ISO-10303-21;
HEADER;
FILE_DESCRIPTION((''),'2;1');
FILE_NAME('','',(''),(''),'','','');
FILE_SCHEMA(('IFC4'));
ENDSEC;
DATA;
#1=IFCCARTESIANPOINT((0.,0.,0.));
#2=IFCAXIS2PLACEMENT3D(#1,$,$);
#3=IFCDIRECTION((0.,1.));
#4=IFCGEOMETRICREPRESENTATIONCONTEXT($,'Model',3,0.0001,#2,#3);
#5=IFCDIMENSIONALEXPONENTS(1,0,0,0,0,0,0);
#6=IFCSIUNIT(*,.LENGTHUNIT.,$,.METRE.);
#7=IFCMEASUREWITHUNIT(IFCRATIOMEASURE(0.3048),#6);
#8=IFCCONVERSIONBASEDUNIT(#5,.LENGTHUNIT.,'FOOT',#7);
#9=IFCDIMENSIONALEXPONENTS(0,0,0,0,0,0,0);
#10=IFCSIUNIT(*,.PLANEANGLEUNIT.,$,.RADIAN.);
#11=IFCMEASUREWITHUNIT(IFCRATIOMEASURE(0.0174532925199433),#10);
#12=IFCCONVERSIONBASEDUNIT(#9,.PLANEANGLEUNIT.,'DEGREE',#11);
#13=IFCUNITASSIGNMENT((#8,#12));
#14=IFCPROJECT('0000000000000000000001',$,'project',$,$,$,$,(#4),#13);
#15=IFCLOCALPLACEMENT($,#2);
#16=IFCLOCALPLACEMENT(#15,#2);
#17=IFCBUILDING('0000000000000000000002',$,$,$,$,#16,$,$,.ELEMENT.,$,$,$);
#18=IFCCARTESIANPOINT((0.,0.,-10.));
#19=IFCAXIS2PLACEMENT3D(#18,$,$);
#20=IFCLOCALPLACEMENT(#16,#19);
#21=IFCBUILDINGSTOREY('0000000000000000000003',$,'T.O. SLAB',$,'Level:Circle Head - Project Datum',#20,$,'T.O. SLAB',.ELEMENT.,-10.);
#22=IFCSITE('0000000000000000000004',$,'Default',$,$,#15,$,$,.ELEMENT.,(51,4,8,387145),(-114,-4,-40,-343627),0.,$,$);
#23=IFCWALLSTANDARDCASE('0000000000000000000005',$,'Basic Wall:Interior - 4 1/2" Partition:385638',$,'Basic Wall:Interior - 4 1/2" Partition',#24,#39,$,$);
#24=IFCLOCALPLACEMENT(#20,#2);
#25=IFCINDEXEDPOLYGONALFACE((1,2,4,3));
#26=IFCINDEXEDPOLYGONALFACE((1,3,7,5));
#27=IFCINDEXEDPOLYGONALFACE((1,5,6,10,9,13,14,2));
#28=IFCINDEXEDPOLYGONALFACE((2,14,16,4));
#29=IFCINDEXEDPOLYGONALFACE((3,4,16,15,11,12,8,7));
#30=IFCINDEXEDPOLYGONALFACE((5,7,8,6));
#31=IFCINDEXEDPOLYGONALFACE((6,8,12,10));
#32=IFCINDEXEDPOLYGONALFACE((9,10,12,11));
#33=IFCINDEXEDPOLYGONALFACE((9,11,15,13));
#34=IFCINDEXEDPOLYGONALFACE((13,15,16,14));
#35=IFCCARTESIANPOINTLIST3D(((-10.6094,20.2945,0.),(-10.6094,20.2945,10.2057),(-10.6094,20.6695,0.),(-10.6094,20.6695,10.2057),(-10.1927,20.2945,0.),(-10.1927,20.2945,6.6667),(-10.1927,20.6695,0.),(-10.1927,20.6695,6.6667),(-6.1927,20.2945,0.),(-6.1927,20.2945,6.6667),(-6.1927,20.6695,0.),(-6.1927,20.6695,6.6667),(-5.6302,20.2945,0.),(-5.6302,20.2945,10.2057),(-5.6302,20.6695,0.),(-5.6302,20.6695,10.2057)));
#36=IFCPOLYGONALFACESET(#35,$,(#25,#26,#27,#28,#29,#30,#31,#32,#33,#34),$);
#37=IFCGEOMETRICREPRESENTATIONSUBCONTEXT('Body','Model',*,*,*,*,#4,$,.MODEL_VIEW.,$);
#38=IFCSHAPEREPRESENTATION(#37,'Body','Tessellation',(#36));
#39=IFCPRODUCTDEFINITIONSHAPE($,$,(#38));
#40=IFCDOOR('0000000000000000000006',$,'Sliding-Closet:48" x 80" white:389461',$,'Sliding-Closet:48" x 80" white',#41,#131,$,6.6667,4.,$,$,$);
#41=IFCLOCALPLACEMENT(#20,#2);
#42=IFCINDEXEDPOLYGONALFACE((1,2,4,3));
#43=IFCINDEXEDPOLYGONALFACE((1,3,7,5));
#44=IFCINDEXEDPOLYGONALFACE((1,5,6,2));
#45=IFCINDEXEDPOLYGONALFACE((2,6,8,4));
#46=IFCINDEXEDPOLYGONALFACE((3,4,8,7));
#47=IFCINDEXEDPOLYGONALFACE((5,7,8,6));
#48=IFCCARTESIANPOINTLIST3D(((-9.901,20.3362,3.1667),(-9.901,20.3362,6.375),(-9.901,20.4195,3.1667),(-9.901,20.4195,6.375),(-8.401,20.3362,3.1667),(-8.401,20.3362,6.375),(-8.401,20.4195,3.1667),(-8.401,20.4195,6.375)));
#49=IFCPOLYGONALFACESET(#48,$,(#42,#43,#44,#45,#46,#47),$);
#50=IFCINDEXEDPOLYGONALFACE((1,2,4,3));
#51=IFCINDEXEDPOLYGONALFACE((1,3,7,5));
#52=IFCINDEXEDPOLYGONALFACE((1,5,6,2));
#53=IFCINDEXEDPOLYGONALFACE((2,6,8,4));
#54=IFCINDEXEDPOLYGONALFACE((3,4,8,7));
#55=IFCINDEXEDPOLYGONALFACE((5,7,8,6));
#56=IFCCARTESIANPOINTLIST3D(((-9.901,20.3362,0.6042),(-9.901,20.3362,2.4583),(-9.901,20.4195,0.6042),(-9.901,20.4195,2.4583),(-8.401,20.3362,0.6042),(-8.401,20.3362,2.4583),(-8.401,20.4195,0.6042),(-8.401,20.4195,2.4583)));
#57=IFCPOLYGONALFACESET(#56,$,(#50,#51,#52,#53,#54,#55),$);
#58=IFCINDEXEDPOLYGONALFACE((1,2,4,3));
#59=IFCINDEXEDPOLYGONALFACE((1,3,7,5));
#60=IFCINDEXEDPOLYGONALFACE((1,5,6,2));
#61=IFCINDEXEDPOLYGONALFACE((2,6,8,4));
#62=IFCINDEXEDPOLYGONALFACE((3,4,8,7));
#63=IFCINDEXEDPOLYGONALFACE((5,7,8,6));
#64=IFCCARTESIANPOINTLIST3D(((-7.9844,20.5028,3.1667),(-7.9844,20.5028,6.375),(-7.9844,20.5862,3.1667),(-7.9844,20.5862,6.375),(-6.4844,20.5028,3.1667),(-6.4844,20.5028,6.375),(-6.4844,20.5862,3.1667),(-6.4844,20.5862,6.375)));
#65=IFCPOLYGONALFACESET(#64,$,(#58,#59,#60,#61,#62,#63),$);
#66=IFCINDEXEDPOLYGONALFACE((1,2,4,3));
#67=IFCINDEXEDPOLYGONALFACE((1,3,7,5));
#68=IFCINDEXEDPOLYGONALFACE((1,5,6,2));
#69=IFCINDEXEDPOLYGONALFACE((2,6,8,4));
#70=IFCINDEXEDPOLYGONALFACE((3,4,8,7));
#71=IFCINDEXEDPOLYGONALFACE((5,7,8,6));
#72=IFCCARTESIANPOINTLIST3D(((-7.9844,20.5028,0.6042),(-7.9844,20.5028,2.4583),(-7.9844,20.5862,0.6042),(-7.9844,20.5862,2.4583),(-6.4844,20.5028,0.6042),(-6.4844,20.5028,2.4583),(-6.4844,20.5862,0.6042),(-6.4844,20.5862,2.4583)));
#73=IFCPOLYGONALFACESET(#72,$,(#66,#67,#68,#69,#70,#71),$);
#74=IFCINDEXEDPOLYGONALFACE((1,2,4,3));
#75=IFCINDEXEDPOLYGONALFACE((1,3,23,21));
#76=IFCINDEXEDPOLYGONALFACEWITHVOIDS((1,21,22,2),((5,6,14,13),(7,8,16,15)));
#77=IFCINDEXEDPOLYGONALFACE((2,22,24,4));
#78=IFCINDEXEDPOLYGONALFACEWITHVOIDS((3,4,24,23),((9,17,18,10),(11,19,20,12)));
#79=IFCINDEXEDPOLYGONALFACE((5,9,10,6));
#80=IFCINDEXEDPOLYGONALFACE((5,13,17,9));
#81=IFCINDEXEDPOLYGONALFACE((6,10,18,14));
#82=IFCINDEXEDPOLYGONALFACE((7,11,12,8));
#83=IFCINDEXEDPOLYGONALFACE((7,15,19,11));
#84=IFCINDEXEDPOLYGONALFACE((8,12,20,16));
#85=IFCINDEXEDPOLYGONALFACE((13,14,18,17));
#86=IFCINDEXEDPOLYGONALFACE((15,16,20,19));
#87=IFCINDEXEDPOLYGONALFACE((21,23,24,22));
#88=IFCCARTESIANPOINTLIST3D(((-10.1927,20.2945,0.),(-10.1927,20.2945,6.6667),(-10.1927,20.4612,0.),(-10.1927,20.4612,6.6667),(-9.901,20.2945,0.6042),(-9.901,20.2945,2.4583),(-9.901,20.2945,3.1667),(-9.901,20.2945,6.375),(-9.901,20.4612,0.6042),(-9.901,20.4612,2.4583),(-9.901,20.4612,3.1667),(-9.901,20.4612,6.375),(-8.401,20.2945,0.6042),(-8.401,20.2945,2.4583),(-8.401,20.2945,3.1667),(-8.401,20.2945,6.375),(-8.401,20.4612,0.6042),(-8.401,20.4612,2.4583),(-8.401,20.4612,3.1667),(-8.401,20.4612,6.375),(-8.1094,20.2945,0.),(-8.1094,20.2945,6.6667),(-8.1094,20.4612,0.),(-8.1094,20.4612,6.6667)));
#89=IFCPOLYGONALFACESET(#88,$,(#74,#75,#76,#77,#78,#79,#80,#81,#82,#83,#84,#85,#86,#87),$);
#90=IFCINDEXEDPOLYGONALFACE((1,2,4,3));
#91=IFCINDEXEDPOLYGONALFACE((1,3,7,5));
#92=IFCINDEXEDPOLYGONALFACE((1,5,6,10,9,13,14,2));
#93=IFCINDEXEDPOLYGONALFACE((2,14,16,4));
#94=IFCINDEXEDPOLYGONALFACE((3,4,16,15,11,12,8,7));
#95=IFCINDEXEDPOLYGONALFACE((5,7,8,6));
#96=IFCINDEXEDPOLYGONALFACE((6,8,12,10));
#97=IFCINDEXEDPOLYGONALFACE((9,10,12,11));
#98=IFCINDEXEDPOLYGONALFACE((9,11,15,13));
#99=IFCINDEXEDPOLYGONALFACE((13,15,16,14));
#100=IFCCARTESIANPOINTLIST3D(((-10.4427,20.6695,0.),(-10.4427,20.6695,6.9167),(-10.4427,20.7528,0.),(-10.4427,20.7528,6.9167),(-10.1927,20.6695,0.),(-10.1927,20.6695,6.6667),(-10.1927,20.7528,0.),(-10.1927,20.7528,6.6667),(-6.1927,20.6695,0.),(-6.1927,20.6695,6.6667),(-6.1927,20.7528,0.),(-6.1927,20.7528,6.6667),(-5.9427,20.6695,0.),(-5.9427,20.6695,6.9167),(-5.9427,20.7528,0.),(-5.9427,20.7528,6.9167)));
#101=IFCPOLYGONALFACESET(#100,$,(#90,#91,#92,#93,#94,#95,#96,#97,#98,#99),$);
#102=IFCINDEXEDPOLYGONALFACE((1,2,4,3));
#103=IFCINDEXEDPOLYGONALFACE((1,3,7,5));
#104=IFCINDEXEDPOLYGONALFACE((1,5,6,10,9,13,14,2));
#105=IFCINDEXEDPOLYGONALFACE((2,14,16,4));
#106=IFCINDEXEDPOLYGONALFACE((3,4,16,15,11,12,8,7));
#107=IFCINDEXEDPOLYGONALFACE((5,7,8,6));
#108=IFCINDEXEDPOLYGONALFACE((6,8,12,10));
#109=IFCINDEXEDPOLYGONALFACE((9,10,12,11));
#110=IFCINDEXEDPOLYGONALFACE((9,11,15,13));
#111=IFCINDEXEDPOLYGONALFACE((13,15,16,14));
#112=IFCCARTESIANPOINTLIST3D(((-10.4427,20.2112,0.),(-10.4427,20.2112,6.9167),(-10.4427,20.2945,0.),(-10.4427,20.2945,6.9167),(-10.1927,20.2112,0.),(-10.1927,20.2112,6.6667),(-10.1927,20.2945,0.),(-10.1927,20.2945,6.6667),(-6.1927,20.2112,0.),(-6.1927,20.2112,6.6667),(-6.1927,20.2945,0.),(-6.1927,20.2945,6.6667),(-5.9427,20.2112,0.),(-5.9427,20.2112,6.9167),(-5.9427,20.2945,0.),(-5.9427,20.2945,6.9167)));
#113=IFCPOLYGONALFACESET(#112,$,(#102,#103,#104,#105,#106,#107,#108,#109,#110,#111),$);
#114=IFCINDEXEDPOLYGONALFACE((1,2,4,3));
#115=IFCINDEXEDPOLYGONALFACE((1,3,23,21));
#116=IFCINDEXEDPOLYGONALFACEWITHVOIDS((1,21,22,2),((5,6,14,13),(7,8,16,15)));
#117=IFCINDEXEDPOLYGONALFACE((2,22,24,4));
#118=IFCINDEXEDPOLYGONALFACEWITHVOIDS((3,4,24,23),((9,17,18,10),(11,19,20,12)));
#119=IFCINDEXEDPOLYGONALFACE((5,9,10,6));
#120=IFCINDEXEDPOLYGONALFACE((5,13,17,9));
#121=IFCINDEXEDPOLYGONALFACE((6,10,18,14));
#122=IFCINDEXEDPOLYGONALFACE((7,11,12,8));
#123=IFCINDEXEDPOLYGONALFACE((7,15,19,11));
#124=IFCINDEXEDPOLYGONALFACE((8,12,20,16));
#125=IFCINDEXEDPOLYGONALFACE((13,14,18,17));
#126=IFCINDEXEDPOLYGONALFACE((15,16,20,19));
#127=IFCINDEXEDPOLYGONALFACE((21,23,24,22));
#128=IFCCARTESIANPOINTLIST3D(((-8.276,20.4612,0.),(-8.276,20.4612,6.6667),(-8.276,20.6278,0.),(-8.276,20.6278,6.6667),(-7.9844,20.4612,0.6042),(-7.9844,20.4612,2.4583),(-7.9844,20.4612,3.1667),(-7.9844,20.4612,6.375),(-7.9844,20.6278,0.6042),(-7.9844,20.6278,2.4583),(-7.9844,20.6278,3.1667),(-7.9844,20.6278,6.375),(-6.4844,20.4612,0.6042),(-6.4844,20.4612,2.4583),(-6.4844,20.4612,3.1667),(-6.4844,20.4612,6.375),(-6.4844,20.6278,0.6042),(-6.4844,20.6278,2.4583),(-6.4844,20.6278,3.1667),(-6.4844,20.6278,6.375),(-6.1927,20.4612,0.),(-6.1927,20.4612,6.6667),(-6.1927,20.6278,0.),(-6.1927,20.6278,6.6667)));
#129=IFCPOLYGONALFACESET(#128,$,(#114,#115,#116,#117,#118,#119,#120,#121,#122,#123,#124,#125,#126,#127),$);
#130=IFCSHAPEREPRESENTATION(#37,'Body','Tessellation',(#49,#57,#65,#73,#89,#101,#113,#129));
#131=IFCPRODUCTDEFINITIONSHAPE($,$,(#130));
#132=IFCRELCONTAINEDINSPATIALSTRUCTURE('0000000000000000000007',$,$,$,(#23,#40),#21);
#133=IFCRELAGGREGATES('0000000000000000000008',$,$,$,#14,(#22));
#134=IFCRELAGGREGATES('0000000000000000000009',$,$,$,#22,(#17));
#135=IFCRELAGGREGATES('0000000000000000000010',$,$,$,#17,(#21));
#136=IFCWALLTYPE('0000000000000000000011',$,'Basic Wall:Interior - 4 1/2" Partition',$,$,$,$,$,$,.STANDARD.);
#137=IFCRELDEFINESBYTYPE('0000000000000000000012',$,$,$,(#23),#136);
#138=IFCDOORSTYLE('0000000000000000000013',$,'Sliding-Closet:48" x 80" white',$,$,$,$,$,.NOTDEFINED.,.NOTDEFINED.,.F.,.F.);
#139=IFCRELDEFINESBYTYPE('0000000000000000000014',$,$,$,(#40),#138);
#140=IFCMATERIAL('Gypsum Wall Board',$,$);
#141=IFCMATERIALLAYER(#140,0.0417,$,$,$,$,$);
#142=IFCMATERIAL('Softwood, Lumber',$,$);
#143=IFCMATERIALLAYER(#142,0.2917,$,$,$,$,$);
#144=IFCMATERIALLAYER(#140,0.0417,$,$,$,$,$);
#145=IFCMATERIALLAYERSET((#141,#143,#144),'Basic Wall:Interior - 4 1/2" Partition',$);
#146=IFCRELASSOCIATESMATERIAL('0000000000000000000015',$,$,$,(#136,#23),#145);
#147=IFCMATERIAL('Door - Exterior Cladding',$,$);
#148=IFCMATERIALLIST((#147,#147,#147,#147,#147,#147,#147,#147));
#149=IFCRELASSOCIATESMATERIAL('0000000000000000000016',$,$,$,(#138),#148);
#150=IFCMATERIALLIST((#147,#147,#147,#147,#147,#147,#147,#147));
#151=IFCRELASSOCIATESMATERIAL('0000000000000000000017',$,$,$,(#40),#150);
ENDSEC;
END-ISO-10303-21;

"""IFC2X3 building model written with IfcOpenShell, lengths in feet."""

from ifc_helpers import new_model, entity, si_unit, converted_unit, direction, frame, frame_2d, origin, origin_2d_with_axis, place, context, subcontext, project, spatial, polyline, rectangle, outline, extrude, source, transform, mapped, material, material_list, layer, layer_set, layer_usage, type_object, type_shapes, element, fill, save


model = new_model("IFC2X3")

# Units and contexts
model_context = context("Model", 3, precision=0.0001, world=origin(), true_north=direction((0.0, 1.0)))
body_context = subcontext(model_context, "Body", "Model", "MODEL_VIEW")
ifc_project = project(units=[converted_unit("LENGTHUNIT", "FOOT", entity("IfcRatioMeasure", 0.3048), si_unit("LENGTHUNIT", "METRE"), dimensions=[1, 0, 0, 0, 0, 0, 0]), converted_unit("PLANEANGLEUNIT", "DEGREE", entity("IfcRatioMeasure", 0.0174532925199433), si_unit("PLANEANGLEUNIT", "RADIAN"), dimensions=[0, 0, 0, 0, 0, 0, 0])], contexts=[model_context])

# Site, building, storey
site_placement = place(None, origin())
site = spatial("IfcSite", under=ifc_project, at=site_placement, Name="Default", CompositionType="ELEMENT", RefLatitude=(51, 4, 8, 387145), RefLongitude=(-114, -4, -40, -343627), RefElevation=0.0)
building_placement = place(site_placement, origin())
building = spatial("IfcBuilding", under=site, at=building_placement, CompositionType="ELEMENT")
storey_placement = place(building_placement, frame((0.0, 0.0, -10.0)))
storey = spatial("IfcBuildingStorey", under=building, at=storey_placement, Name="T.O. SLAB", ObjectType="Level:Circle Head - Project Datum", LongName="T.O. SLAB", CompositionType="ELEMENT", Elevation=-10.0)

# Shared definitions
ifc_material_1 = material(Name="Gypsum Wall Board")
ifc_layer_1 = layer(ifc_material_1, 0.0417)
ifc_material_2 = material(Name="Softwood, Lumber")
ifc_layer_2 = layer(ifc_material_2, 0.2917)
ifc_layer_3 = layer(ifc_material_1, 0.0417)
ifc_layer_set_1 = layer_set([ifc_layer_1, ifc_layer_2, ifc_layer_3], Name="Basic Wall:Interior - 4 1/2\" Partition")
wall_type_1 = type_object("IfcWallType", Name="Basic Wall:Interior - 4 1/2\" Partition", PredefinedType="STANDARD", material=ifc_layer_set_1)

# Shared definitions
ifc_material_3 = material(Name="Door - Exterior Cladding")

# Wall, opening, door
ifc_layer_usage_1 = layer_usage(ifc_layer_set_1, "AXIS2", "NEGATIVE", 0.1875)
wall_1_placement = place(storey_placement, frame((-10.6094, 20.482, 0.0)))
wall_1 = element("IfcWallStandardCase", 1, at=wall_1_placement, inside=storey, type_object=wall_type_1, material=ifc_layer_usage_1, Name="Basic Wall:Interior - 4 1/2\" Partition:385638", ObjectType="Basic Wall:Interior - 4 1/2\" Partition", context=body_context, shape_type="SweptSolid", body=[
    extrude(rectangle(XDim=4.9792, YDim=0.375, at=frame_2d((2.4896, 0.0), x_axis=(-1.0, 0.0))), origin(), (0.0, 0.0, 1.0), 10.2057),
])
opening_1_placement = place(wall_1_placement, frame((4.4167, 0.1875, 0.0)))
opening_1 = element("IfcOpeningElement", 2, at=opening_1_placement, cuts=wall_1, ObjectType="Opening", context=body_context, shape_type="SweptSolid", body=[
    extrude(rectangle(XDim=6.6667, YDim=4.0, at=frame_2d((3.3333, 2.0), x_axis=(-1.0, 0.0))), frame((0.0, 0.0, 0.0), z_axis=(0.0, -1.0, 0.0), x_axis=(0.0, 0.0, 1.0)), (0.0, 0.0, 1.0), 0.375),
])
ifc_material_list_1 = material_list([ifc_material_3, ifc_material_3, ifc_material_3, ifc_material_3, ifc_material_3, ifc_material_3, ifc_material_3, ifc_material_3])
ifc_material_list_2 = material_list([ifc_material_3, ifc_material_3, ifc_material_3, ifc_material_3, ifc_material_3, ifc_material_3, ifc_material_3, ifc_material_3])
door_style_1 = type_object("IfcDoorStyle", Name="Sliding-Closet:48\" x 80\" white", ConstructionType="NOTDEFINED", OperationType="NOTDEFINED", ParameterTakesPrecedence=False, Sizeable=False, material=ifc_material_list_2)
shared_shape_1 = source(origin(), body_context, "Body", "SweptSolid", [
    extrude(rectangle(XDim=1.5, YDim=0.0833, at=origin_2d_with_axis()), frame((2.9583, 1.125, 3.1667)), (0.0, 0.0, 1.0), 3.2083),
    extrude(rectangle(XDim=1.5, YDim=0.0833, at=frame_2d((0.0, 0.0), x_axis=(1.0, 0.0))), frame((2.9583, 1.125, 0.6042)), (0.0, 0.0, 1.0), 1.8542),
    extrude(rectangle(XDim=1.5, YDim=0.0833, at=origin_2d_with_axis()), frame((1.0417, 0.9583, 3.1667), z_axis=(0.0, 0.0, 1.0), x_axis=(-1.0, 0.0, 0.0)), (0.0, 0.0, 1.0), 3.2083),
    extrude(rectangle(XDim=1.5, YDim=0.0833, at=origin_2d_with_axis()), frame((1.0417, 0.9583, 0.6042), z_axis=(0.0, 0.0, 1.0), x_axis=(-1.0, 0.0, 0.0)), (0.0, 0.0, 1.0), 1.8542),
    extrude(outline(polyline([(-3.3333, -1.0417), (3.3333, -1.0417), (3.3333, 1.0417), (-3.3333, 1.0417), (-3.3333, -1.0417)]), holes=[polyline([(2.7292, 0.75), (2.7292, -0.75), (0.875, -0.75), (0.875, 0.75), (2.7292, 0.75)]), polyline([(0.1667, 0.75), (0.1667, -0.75), (-3.0417, -0.75), (-3.0417, 0.75), (0.1667, 0.75)])]), frame((2.9583, 1.2083, 3.3333), z_axis=(0.0, -1.0, 0.0), x_axis=(0.0, 0.0, -1.0)), (0.0, 0.0, 1.0), 0.1667),
    extrude(outline(polyline([(-3.3958, -2.25), (3.5208, -2.25), (3.5208, 2.25), (-3.3958, 2.25), (-3.3958, 2.0), (3.2708, 2.0), (3.2708, -2.0), (-3.3958, -2.0), (-3.3958, -2.25)])), frame((2.0, 0.8333, 3.3958), z_axis=(0.0, -1.0, 0.0), x_axis=(0.0, 0.0, 1.0)), (0.0, 0.0, 1.0), 0.0833),
    extrude(outline(polyline([(-2.25, -3.3958), (-2.0, -3.3958), (-2.0, 3.2708), (2.0, 3.2708), (2.0, -3.3958), (2.25, -3.3958), (2.25, 3.5208), (-2.25, 3.5208), (-2.25, -3.3958)])), frame((2.0, 1.2917, 3.3958), z_axis=(0.0, -1.0, 0.0), x_axis=(1.0, 0.0, 0.0)), (0.0, 0.0, 1.0), 0.0833),
    extrude(outline(polyline([(-1.0417, -3.3333), (1.0417, -3.3333), (1.0417, 3.3333), (-1.0417, 3.3333), (-1.0417, -3.3333)]), holes=[polyline([(0.75, 0.1667), (0.75, -3.0417), (-0.75, -3.0417), (-0.75, 0.1667), (0.75, 0.1667)]), polyline([(0.75, 2.7292), (0.75, 0.875), (-0.75, 0.875), (-0.75, 2.7292), (0.75, 2.7292)])]), frame((1.0417, 1.0417, 3.3333), z_axis=(0.0, -1.0, 0.0), x_axis=(-1.0, 0.0, 0.0)), (0.0, 0.0, 1.0), 0.1667),
])
type_shapes(door_style_1, [shared_shape_1])
door_1_placement = place(opening_1_placement, frame((0.0, 0.8333, 0.0), z_axis=(0.0, 0.0, 1.0), x_axis=(-1.0, 0.0, 0.0)))
door_1 = element("IfcDoor", 3, at=door_1_placement, inside=storey, type_object=door_style_1, material=ifc_material_list_1, Name="Sliding-Closet:48\" x 80\" white:389461", ObjectType="Sliding-Closet:48\" x 80\" white", OverallHeight=6.6667, OverallWidth=4.0, context=body_context, shape_type="MappedRepresentation", body=[
    mapped(shared_shape_1, transform((0.0, 0.0, 0.0), scale=1.0)),
])
fill(opening_1, door_1)

save(model, "model.ifc")
